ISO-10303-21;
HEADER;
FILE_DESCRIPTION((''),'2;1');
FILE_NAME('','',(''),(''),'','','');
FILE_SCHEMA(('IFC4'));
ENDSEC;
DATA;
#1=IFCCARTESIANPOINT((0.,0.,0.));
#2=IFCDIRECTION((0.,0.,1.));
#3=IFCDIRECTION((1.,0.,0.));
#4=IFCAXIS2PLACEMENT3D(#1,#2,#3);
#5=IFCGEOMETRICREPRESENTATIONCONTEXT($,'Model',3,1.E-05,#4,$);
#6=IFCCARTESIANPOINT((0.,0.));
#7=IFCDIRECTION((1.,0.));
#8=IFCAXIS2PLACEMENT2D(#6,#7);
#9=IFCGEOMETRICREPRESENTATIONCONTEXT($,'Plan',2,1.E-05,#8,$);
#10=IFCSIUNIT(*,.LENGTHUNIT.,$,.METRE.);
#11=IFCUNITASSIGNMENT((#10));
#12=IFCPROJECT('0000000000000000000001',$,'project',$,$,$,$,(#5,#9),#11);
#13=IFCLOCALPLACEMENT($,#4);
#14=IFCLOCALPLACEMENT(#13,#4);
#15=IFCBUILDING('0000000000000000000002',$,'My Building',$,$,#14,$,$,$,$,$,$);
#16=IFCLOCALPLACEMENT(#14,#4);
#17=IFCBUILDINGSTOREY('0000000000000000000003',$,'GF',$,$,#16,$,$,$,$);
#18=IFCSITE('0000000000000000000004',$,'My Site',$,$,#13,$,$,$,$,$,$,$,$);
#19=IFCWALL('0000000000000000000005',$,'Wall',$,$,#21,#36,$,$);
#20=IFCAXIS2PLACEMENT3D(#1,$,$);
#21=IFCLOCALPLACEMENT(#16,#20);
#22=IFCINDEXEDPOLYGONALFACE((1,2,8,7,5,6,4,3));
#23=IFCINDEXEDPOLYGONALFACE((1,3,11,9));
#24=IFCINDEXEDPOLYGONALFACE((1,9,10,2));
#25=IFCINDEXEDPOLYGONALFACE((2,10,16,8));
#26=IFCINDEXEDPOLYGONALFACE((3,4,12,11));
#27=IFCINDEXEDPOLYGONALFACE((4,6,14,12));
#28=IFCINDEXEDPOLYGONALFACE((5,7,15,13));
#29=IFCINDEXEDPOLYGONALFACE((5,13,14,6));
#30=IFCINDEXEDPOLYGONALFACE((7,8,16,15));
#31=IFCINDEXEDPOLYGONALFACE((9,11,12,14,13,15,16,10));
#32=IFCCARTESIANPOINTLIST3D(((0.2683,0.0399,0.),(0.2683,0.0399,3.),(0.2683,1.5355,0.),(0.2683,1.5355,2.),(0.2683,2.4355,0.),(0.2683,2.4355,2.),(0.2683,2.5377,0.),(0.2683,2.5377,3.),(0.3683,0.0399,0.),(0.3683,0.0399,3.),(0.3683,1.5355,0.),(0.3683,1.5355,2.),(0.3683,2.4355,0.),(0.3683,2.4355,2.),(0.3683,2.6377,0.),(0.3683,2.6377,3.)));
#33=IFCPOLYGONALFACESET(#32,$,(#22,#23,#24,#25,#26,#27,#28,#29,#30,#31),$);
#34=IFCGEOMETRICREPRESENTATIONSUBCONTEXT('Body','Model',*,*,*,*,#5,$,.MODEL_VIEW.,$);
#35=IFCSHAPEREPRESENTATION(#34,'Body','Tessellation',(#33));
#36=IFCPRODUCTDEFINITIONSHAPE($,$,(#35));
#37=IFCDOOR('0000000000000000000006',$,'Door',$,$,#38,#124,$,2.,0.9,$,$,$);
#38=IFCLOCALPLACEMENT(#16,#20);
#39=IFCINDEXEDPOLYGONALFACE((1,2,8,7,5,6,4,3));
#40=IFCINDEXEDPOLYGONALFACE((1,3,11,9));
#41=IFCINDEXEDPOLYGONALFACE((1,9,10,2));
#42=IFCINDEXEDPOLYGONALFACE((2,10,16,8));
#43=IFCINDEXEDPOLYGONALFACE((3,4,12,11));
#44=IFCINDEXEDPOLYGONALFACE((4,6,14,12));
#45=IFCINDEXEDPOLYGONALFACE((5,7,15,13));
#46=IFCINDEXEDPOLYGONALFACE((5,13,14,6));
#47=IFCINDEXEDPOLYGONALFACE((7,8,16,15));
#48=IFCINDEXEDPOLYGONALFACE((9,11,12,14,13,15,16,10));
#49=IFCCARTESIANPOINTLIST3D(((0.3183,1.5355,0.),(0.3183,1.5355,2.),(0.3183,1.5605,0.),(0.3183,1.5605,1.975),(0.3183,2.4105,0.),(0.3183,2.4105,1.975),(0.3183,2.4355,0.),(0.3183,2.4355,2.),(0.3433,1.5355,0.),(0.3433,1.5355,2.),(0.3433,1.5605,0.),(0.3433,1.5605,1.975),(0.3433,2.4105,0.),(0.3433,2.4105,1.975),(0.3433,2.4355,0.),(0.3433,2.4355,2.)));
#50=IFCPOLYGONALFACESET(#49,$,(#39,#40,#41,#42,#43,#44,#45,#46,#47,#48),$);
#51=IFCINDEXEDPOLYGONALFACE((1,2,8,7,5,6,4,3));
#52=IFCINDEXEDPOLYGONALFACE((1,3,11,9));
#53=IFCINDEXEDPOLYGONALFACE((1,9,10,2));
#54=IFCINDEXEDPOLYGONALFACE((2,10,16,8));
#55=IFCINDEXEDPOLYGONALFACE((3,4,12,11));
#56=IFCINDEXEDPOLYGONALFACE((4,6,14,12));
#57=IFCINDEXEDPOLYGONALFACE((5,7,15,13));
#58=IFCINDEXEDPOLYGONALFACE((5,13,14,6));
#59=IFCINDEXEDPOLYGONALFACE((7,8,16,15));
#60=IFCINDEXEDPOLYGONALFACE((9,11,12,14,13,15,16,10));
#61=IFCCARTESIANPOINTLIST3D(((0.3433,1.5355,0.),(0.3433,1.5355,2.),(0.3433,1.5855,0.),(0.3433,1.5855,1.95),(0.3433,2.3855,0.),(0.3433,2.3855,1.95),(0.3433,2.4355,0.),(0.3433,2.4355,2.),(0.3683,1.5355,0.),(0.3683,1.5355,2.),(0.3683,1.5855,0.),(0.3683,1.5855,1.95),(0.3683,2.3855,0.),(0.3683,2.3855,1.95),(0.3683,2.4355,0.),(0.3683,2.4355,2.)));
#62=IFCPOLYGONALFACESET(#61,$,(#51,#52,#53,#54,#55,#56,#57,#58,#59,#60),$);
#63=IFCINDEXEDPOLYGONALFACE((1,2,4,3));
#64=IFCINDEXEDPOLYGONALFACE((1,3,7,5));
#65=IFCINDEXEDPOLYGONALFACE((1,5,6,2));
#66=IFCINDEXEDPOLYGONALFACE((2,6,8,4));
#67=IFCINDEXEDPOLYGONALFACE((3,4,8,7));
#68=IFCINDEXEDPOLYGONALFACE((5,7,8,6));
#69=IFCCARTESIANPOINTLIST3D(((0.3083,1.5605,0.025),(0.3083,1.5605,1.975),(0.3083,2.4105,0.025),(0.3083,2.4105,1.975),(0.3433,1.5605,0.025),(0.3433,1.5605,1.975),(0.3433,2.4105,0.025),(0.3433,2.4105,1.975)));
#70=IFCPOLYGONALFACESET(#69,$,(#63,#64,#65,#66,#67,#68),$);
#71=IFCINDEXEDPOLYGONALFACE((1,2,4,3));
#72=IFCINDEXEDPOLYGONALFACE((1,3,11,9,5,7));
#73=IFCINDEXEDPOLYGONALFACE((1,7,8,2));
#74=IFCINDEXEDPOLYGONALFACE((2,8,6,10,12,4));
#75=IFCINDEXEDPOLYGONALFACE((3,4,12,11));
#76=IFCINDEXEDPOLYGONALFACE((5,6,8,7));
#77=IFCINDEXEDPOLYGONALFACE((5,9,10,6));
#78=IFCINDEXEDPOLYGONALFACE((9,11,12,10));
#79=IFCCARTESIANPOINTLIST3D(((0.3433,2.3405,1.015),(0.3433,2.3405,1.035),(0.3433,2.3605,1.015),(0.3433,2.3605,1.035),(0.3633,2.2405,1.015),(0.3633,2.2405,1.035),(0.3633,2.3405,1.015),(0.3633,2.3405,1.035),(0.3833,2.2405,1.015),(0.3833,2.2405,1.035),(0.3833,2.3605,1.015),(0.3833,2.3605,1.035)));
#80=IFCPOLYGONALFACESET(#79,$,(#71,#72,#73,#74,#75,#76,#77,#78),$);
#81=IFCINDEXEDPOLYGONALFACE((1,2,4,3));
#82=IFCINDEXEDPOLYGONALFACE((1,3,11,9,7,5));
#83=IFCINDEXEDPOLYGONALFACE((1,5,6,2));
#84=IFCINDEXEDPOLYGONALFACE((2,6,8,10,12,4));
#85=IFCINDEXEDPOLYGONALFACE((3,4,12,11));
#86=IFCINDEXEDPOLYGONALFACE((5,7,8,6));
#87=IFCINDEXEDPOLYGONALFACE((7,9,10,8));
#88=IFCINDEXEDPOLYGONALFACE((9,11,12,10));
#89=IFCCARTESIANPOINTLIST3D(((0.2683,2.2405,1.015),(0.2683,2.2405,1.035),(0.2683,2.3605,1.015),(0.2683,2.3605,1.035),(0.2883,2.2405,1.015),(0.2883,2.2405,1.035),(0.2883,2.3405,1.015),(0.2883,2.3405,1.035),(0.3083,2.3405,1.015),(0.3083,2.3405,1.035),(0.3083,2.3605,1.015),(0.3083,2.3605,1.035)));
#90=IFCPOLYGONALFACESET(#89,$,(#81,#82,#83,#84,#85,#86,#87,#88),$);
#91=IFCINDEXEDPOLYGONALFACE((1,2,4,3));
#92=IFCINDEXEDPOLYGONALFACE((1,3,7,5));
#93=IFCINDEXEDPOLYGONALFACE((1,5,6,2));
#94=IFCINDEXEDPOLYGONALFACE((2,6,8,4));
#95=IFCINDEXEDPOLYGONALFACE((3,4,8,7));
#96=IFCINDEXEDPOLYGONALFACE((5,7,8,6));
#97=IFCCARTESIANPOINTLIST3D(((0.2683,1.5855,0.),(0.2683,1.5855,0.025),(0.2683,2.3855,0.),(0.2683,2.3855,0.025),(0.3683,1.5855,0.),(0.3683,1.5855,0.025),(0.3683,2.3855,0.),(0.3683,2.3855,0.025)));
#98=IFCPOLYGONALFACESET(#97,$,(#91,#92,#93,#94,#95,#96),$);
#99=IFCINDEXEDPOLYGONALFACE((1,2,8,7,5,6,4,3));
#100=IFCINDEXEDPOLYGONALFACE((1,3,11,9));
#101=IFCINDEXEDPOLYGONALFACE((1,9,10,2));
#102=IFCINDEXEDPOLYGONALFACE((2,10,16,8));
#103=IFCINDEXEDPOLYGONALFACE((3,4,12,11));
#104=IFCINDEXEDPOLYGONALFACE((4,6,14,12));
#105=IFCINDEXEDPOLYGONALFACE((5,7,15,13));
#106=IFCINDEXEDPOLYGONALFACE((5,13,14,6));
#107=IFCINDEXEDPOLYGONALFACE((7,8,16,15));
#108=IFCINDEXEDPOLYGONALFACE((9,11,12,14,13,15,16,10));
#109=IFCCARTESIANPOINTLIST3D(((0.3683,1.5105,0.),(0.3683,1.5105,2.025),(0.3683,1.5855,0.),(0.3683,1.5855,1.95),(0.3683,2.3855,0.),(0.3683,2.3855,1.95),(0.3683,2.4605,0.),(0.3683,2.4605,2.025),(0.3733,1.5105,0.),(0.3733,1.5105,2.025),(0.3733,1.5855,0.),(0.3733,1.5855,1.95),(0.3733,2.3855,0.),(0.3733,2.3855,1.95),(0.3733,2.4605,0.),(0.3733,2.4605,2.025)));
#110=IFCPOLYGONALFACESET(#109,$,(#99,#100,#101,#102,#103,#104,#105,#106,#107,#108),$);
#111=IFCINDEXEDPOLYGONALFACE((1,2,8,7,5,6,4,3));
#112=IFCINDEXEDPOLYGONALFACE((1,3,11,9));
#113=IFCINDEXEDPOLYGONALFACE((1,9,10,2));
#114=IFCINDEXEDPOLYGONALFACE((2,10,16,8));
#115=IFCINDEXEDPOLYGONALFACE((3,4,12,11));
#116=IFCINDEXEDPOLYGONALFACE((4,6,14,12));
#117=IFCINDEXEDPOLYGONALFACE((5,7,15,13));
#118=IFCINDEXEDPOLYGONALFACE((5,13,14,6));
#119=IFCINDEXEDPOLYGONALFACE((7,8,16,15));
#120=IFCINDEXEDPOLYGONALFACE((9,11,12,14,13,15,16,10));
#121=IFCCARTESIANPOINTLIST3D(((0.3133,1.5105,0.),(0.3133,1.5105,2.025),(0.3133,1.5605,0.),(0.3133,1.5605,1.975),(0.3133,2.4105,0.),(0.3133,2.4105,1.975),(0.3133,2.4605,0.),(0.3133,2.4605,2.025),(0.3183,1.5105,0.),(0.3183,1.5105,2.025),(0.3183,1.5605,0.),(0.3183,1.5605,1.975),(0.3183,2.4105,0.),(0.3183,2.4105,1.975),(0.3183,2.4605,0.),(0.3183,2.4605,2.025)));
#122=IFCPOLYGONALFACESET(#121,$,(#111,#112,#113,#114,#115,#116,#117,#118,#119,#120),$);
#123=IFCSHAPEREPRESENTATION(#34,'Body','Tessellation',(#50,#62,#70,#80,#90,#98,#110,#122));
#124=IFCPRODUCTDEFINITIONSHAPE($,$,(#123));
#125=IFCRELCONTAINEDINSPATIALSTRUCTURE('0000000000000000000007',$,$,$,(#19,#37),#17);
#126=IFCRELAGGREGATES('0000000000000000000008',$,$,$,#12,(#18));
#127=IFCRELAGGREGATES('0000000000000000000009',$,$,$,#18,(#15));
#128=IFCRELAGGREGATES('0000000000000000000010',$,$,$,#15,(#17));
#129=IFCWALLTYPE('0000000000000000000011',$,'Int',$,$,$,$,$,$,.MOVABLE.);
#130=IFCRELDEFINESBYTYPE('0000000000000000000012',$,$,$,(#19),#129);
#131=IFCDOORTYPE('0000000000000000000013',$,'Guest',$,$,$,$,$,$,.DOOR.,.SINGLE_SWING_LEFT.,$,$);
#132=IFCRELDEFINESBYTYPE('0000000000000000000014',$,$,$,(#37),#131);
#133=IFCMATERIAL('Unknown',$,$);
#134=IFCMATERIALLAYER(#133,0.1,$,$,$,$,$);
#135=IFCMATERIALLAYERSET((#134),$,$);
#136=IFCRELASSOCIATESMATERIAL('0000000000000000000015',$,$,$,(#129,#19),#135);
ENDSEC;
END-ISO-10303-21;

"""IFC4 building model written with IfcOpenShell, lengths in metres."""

from ifc_helpers import new_model, entity, si_unit, frame, origin_with_axes, origin_2d_with_axis, place, context, subcontext, project, spatial, line, indexed_curve, outline, extrude, shape, source, transform, mapped, material, layer, layer_set, layer_usage, type_object, type_shapes, element, fill, save


model = new_model("IFC4")

# Units and contexts
model_context = context("Model", 3, precision=1e-05, world=origin_with_axes())
plan_context = context("Plan", 2, precision=1e-05, world=origin_2d_with_axis())
body_context_1 = subcontext(model_context, "Body", "Model", "MODEL_VIEW")
body_context_2 = subcontext(plan_context, "Body", "Plan", "PLAN_VIEW")
ifc_project = project(units=[si_unit("LENGTHUNIT", "METRE")], contexts=[model_context, plan_context])

# Site, building, storey
site_placement = place(None, origin_with_axes())
site = spatial("IfcSite", under=ifc_project, at=site_placement, Name="My Site")
building_placement = place(site_placement, origin_with_axes())
building = spatial("IfcBuilding", under=site, at=building_placement, Name="My Building")
storey_placement = place(building_placement, origin_with_axes())
storey = spatial("IfcBuildingStorey", under=building, at=storey_placement, Name="GF")

# Shared definitions
ifc_material = material(Name="Unknown")

# Shared definitions
ifc_layer_1 = layer(ifc_material, 0.1)
ifc_layer_set_1 = layer_set([ifc_layer_1])
wall_type_1 = type_object("IfcWallType", Name="Int", PredefinedType="MOVABLE", material=ifc_layer_set_1)

# Wall, opening, door
ifc_layer_usage_1 = layer_usage(ifc_layer_set_1, "AXIS2", "POSITIVE", 0.0)
wall_1_placement = place(storey_placement, frame((0.2683, 2.5377, 0.0), z_axis=(0.0, 0.0, 1.0), x_axis=(0.0, -1.0, 0.0)))
wall_1 = element("IfcWall", 1, at=wall_1_placement, inside=storey, type_object=wall_type_1, material=ifc_layer_usage_1, Name="Wall", context=body_context_1, shape_type="SweptSolid", body=[
    extrude(outline(indexed_curve([(0.0, 0.0), (-0.1, 0.1), (2.4978, 0.1), (2.4978, 0.0)], segments=[line(1, 2, 3, 4, 1)])), origin_with_axes(), (0.0, 0.0, 1.0), 3.0),
])
shared_shape_1 = source(origin_with_axes(), body_context_1, "Body", "SweptSolid", [
    extrude(outline(indexed_curve([(0.0, 0.0), (0.9, 0.0), (0.9, 2.0), (0.0, 2.0)], segments=[line(1, 2, 3, 4, 1)])), frame((0.0, -0.6, 0.0), z_axis=(0.0, -1.0, 0.0), x_axis=(1.0, 0.0, 0.0)), (0.0, 0.0, -1.0), 1.2),
])
opening_1_placement = place(wall_1_placement, frame((1.0022, 0.1, 0.0), z_axis=(0.0, 0.0, 1.0), x_axis=(-1.0, 0.0, 0.0)))
opening_1 = element("IfcOpeningElement", 2, at=opening_1_placement, cuts=wall_1, PredefinedType="OPENING", context=body_context_1, shape_type="MappedRepresentation", body=[
    mapped(shared_shape_1, transform((0.0, 0.0, 0.0), x_axis=(1.0, 0.0, 0.0), y_axis=(0.0, 1.0, 0.0), z_axis=(0.0, 0.0, 1.0), scale=1.0)),
])
door_type_1 = type_object("IfcDoorType", Name="Guest", OperationType="SINGLE_SWING_LEFT", PredefinedType="DOOR")
shared_shape_2 = source(origin_with_axes(), body_context_1, "Body", "SweptSolid", [
    extrude(outline(indexed_curve([(0.0, 0.0), (0.0, 2.0), (0.9, 2.0), (0.9, 0.0), (0.875, 0.0), (0.875, 1.975), (0.025, 1.975), (0.025, 0.0)], segments=[line(1, 2, 3, 4, 5, 6, 7, 8, 1)])), frame((0.0, 0.025, 0.0), z_axis=(0.0, -1.0, 0.0), x_axis=(1.0, 0.0, 0.0)), (0.0, 0.0, -1.0), 0.025),
    extrude(outline(indexed_curve([(0.0, 0.0), (0.0, 2.0), (0.9, 2.0), (0.9, 0.0), (0.85, 0.0), (0.85, 1.95), (0.05, 1.95), (0.05, 0.0)], segments=[line(1, 2, 3, 4, 5, 6, 7, 8, 1)])), frame((0.0, 0.0, 0.0), z_axis=(0.0, -1.0, 0.0), x_axis=(1.0, 0.0, 0.0)), (0.0, 0.0, -1.0), 0.025),
    extrude(outline(indexed_curve([(0.0, 0.0), (0.85, 0.0), (0.85, 0.035), (0.0, 0.035)], segments=[line(1, 2, 3, 4, 1)])), frame((0.025, 0.025, 0.025), z_axis=(0.0, 0.0, 1.0), x_axis=(1.0, 0.0, 0.0)), (0.0, 0.0, 1.0), 1.95),
    extrude(outline(indexed_curve([(0.0, 0.0), (0.0, -0.04), (-0.12, -0.04), (-0.12, -0.02), (-0.02, -0.02), (-0.02, 0.0)], segments=[line(1, 2, 3, 4, 5, 6, 1)])), frame((0.825, 0.025, 1.015), z_axis=(0.0, 0.0, 1.0), x_axis=(1.0, 0.0, 0.0)), (0.0, 0.0, 1.0), 0.02),
    extrude(outline(indexed_curve([(0.0, 0.0), (0.0, 0.04), (-0.12, 0.04), (-0.12, 0.02), (-0.02, 0.02), (-0.02, 0.0)], segments=[line(1, 2, 3, 4, 5, 6, 1)])), frame((0.825, 0.06, 1.015), z_axis=(0.0, 0.0, 1.0), x_axis=(1.0, 0.0, 0.0)), (0.0, 0.0, 1.0), 0.02),
    extrude(outline(indexed_curve([(0.0, 0.0), (0.8, 0.0), (0.8, 0.1), (0.0, 0.1)], segments=[line(1, 2, 3, 4, 1)])), frame((0.05, 0.0, 0.0), z_axis=(0.0, 0.0, 1.0), x_axis=(1.0, 0.0, 0.0)), (0.0, 0.0, 1.0), 0.025),
    extrude(outline(indexed_curve([(0.0, 0.0), (0.0, 2.025), (0.95, 2.025), (0.95, 0.0), (0.875, 0.0), (0.875, 1.95), (0.075, 1.95), (0.075, 0.0)], segments=[line(1, 2, 3, 4, 5, 6, 7, 8, 1)])), frame((-0.025, -0.005, 0.0), z_axis=(0.0, -1.0, 0.0), x_axis=(1.0, 0.0, 0.0)), (0.0, 0.0, -1.0), 0.005),
    extrude(outline(indexed_curve([(0.0, 0.0), (0.0, 2.025), (0.95, 2.025), (0.95, 0.0), (0.9, 0.0), (0.9, 1.975), (0.05, 1.975), (0.05, 0.0)], segments=[line(1, 2, 3, 4, 5, 6, 7, 8, 1)])), frame((-0.025, 0.05, 0.0), z_axis=(0.0, -1.0, 0.0), x_axis=(1.0, 0.0, 0.0)), (0.0, 0.0, -1.0), 0.005),
])
shared_shape_3 = source(origin_with_axes(), body_context_2, "Body", "Curve2D", [
    entity("IfcIndexedPolyCurve", entity("IfcCartesianPointList2D", [[0.0, 0.0], [0.0, 0.05], [0.025, 0.05], [0.025, 0.025], [0.05, 0.025], [0.05, 0.0]]), [entity("IfcLineIndex", [1, 2, 3, 4, 5, 6, 1])]),
    entity("IfcIndexedPolyCurve", entity("IfcCartesianPointList2D", [[0.9, 0.0], [0.9, 0.05], [0.875, 0.05], [0.875, 0.025], [0.85, 0.025], [0.85, 0.0]]), [entity("IfcLineIndex", [1, 2, 3, 4, 5, 6, 1])]),
    entity("IfcTrimmedCurve", entity("IfcEllipse", entity("IfcAxis2Placement2D", entity("IfcCartesianPoint", [0.06, 0.05]), entity("IfcDirection", [1.0, 0.0])), 0.815, 0.85), [entity("IfcCartesianPoint", [0.875, 0.05])], [entity("IfcCartesianPoint", [0.06, 0.9])], True, "CARTESIAN"),
    entity("IfcIndexedPolyCurve", entity("IfcCartesianPointList2D", [[0.025, 0.05], [0.06, 0.05], [0.06, 0.9], [0.025, 0.9]]), [entity("IfcLineIndex", [1, 2, 3, 4, 1])]),
])
type_shapes(door_type_1, [shared_shape_2, shared_shape_3])
door_1_placement = place(opening_1_placement, frame((0.0, 0.0, 0.0), z_axis=(0.0, 0.0, 1.0), x_axis=(1.0, 0.0, 0.0)))
door_1 = element("IfcDoor", 3, at=door_1_placement, inside=storey, type_object=door_type_1, Name="Door", OverallHeight=2.0, OverallWidth=0.9, shapes=[
    shape(body_context_1, "Body", "MappedRepresentation", [mapped(shared_shape_2, transform((0.0, 0.0, 0.0), x_axis=(1.0, 0.0, 0.0), y_axis=(0.0, 1.0, 0.0), z_axis=(0.0, 0.0, 1.0), scale=1.0))]),
    shape(body_context_2, "Body", "MappedRepresentation", [mapped(shared_shape_3, transform((0.0, 0.0, 0.0), x_axis=(1.0, 0.0, 0.0), y_axis=(0.0, 1.0, 0.0), z_axis=(0.0, 0.0, 1.0), scale=1.0))]),
])
fill(opening_1, door_1)

save(model, "model.ifc")
